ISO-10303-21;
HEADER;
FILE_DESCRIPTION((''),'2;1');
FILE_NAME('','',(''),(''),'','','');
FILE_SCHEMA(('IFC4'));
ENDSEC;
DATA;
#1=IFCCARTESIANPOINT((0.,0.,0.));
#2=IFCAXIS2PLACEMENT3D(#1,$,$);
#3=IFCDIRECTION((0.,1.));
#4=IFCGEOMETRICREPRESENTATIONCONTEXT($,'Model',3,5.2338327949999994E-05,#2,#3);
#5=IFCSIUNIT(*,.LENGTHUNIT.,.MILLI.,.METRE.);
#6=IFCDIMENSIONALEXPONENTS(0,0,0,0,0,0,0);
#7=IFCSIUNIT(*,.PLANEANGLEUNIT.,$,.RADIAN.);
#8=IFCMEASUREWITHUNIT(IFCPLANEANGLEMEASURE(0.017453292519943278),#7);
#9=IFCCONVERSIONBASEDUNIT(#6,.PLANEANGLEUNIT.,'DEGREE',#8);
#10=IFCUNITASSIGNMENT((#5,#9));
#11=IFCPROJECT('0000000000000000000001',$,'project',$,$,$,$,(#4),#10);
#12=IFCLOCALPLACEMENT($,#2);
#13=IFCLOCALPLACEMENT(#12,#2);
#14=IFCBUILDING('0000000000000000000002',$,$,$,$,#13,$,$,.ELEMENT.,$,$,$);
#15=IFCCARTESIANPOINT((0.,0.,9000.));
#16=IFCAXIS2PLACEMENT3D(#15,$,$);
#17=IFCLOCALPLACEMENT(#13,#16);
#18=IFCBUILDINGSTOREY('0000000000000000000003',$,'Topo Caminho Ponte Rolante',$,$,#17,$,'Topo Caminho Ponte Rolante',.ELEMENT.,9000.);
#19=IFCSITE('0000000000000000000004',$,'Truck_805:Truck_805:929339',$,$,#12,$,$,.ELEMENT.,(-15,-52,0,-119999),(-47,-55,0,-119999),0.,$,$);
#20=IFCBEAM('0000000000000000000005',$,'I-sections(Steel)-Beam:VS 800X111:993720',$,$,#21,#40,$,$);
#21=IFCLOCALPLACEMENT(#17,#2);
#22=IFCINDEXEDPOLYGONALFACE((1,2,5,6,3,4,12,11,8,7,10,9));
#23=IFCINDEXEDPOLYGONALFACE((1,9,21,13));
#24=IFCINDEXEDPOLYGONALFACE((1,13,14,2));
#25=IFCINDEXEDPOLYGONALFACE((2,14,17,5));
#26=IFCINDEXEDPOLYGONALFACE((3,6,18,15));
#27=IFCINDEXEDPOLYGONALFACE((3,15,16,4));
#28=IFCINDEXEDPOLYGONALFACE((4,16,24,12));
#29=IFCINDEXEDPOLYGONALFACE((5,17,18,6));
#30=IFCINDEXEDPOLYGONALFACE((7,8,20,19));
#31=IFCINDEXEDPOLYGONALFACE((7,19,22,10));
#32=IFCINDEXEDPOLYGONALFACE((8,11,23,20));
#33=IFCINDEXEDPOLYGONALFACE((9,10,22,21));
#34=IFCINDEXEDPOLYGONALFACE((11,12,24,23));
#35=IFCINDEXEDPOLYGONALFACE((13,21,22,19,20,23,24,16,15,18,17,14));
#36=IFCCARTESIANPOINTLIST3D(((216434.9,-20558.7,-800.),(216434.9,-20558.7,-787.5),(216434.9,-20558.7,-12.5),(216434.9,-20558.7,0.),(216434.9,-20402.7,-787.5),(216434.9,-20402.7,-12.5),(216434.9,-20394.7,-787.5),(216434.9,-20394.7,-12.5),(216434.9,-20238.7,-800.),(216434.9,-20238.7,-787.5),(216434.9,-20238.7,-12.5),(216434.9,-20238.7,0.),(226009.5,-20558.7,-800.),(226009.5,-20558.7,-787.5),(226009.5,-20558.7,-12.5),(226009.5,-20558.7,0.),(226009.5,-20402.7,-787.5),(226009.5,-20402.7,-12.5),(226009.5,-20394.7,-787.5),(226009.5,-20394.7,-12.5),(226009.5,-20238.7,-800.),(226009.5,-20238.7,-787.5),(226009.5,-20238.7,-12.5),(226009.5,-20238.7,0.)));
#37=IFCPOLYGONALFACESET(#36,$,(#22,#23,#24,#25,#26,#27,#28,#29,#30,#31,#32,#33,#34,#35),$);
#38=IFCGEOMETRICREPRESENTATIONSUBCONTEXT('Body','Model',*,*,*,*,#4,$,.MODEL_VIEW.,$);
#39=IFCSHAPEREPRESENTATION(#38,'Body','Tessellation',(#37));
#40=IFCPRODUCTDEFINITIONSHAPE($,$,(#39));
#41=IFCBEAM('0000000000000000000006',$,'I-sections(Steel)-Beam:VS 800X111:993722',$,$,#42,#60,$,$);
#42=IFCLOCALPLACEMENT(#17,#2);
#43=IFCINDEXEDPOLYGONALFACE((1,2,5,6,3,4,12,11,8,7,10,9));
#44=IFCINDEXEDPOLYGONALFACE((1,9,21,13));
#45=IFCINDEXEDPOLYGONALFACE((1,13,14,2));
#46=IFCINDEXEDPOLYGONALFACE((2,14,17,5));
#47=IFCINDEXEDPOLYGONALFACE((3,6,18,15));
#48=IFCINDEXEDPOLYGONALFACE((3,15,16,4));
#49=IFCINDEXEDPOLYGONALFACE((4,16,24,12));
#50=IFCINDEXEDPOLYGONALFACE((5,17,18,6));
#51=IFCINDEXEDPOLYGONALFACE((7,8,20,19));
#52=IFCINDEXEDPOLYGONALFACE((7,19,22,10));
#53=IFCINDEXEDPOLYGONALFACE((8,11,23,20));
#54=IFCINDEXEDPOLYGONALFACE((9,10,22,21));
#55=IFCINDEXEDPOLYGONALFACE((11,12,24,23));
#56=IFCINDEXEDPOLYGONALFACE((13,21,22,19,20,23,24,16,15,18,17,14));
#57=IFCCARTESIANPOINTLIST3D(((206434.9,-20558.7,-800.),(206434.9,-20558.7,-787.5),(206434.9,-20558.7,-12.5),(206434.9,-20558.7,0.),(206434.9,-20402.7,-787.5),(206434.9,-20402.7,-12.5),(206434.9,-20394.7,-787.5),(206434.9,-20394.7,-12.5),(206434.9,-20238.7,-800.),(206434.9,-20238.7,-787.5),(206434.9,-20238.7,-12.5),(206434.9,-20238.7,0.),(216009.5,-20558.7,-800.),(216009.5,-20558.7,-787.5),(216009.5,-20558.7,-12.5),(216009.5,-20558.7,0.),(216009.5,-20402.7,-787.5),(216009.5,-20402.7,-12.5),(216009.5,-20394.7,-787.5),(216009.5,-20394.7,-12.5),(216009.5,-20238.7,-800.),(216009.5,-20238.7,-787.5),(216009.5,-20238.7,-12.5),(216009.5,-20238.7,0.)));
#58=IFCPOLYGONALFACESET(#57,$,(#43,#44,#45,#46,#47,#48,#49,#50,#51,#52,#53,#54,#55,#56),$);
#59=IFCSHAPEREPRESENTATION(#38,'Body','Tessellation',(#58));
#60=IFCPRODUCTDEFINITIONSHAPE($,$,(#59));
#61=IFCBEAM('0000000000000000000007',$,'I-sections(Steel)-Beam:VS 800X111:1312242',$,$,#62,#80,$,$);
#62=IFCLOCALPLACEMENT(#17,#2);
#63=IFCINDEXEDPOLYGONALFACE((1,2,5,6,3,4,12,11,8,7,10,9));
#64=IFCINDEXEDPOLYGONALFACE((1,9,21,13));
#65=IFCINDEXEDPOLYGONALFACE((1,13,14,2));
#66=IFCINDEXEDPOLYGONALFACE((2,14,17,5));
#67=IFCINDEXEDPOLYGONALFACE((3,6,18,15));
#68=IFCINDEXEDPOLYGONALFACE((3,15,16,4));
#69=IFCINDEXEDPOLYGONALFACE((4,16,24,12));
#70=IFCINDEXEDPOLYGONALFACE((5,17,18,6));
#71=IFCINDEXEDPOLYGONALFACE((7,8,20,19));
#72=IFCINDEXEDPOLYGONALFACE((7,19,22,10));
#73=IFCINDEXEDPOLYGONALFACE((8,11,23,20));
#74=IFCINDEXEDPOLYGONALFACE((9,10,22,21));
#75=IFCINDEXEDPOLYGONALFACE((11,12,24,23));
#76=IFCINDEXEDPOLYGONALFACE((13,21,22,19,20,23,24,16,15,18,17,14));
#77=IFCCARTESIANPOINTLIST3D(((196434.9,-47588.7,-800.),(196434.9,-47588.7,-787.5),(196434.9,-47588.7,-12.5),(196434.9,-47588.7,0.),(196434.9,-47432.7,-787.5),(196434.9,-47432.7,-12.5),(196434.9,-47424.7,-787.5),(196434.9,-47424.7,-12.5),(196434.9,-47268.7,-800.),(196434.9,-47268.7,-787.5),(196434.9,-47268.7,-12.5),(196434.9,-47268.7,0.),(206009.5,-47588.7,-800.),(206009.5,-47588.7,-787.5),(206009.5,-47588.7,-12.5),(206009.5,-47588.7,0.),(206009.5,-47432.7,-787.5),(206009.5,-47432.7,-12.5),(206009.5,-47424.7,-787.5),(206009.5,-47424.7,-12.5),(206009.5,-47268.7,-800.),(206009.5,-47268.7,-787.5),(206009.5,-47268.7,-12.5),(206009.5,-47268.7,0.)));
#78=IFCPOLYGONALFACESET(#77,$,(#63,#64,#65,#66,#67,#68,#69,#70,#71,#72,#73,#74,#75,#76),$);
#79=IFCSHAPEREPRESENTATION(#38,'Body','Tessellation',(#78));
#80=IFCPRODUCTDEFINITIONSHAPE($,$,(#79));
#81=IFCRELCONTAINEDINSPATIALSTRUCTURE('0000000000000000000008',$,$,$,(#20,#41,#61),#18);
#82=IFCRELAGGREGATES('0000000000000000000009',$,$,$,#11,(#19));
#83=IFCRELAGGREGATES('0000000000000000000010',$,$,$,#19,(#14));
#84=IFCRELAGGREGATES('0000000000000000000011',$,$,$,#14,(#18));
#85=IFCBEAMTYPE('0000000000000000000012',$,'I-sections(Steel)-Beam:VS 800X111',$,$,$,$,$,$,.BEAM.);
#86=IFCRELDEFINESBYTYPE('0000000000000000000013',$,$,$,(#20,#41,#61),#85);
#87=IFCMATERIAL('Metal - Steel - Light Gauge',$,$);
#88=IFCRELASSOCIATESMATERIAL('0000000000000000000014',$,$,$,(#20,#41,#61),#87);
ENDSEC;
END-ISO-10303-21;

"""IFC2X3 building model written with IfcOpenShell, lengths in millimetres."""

from ifc_helpers import new_model, entity, si_unit, converted_unit, direction, frame, frame_2d, origin, place, context, subcontext, project, spatial, polyline, i_section, outline, extrude, material, type_object, element, save


model = new_model("IFC2X3")

# Units and contexts
model_context = context("Model", 3, precision=5.2338327949999994e-05, world=origin(), true_north=direction((0.0, 1.0)))
body_context = subcontext(model_context, "Body", "Model", "MODEL_VIEW")
ifc_project = project(units=[si_unit("LENGTHUNIT", "METRE", prefix="MILLI"), converted_unit("PLANEANGLEUNIT", "DEGREE", entity("IfcPlaneAngleMeasure", 0.017453292519943278), si_unit("PLANEANGLEUNIT", "RADIAN"), dimensions=[0, 0, 0, 0, 0, 0, 0])], contexts=[model_context])

# Site, building, storey
site_placement = place(None, origin())
site = spatial("IfcSite", under=ifc_project, at=site_placement, Name="Truck_805:Truck_805:929339", CompositionType="ELEMENT", RefLatitude=(-15, -52, 0, -119999), RefLongitude=(-47, -55, 0, -119999), RefElevation=0.0)
building_placement = place(site_placement, origin())
building = spatial("IfcBuilding", under=site, at=building_placement, CompositionType="ELEMENT")
storey_placement = place(building_placement, frame((0.0, 0.0, 9000.0)))
storey = spatial("IfcBuildingStorey", under=building, at=storey_placement, Name="Topo Caminho Ponte Rolante", LongName="Topo Caminho Ponte Rolante", CompositionType="ELEMENT", Elevation=9000.0)

# Beams
ifc_material = material(Name="Metal - Steel - Light Gauge")
beam_type_1 = type_object("IfcBeamType", Name="I-sections(Steel)-Beam:VS 800X111", PredefinedType="BEAM")
beam_1_placement = place(storey_placement, frame((216222.2, -20398.7, 0.0)))
element("IfcBeam", 1, at=beam_1_placement, inside=storey, type_object=beam_type_1, material=ifc_material, Name="I-sections(Steel)-Beam:VS 800X111:993720", context=body_context, shape_type="SweptSolid", body=[
    extrude(outline(polyline([(387.5, -160.0), (400.0, -160.0), (400.0, 160.0), (387.5, 160.0), (387.5, 4.0), (-387.5, 4.0), (-387.5, 160.0), (-400.0, 160.0), (-400.0, -160.0), (-387.5, -160.0), (-387.5, -4.0), (387.5, -4.0), (387.5, -160.0)])), frame((212.7, 0.0, -400.0), z_axis=(1.0, 0.0, 0.0), x_axis=(0.0, 0.0, -1.0)), (0.0, 0.0, 1.0), 9574.6),
])
beam_2_placement = place(storey_placement, frame((206222.2, -20398.7, 0.0)))
element("IfcBeam", 2, at=beam_2_placement, inside=storey, type_object=beam_type_1, material=ifc_material, Name="I-sections(Steel)-Beam:VS 800X111:993722", context=body_context, shape_type="SweptSolid", body=[
    extrude(outline(polyline([(387.5, -160.0), (400.0, -160.0), (400.0, 160.0), (387.5, 160.0), (387.5, 4.0), (-387.5, 4.0), (-387.5, 160.0), (-400.0, 160.0), (-400.0, -160.0), (-387.5, -160.0), (-387.5, -4.0), (387.5, -4.0), (387.5, -160.0)])), frame((212.7, 0.0, -400.0), z_axis=(1.0, 0.0, 0.0), x_axis=(0.0, 0.0, -1.0)), (0.0, 0.0, 1.0), 9574.6),
])
beam_3_placement = place(storey_placement, frame((196222.2, -47428.7, 0.0)))
element("IfcBeam", 3, at=beam_3_placement, inside=storey, type_object=beam_type_1, material=ifc_material, Name="I-sections(Steel)-Beam:VS 800X111:1312242", context=body_context, shape_type="SweptSolid", body=[
    extrude(i_section(OverallWidth=320.0, OverallDepth=800.0, WebThickness=8.0, FlangeThickness=12.5, at=frame_2d((0.0, 0.0), x_axis=(0.0, 1.0))), frame((212.7, 0.0, -400.0), z_axis=(1.0, 0.0, 0.0), x_axis=(0.0, 0.0, -1.0)), (0.0, 0.0, 1.0), 9574.6),
])

save(model, "model.ifc")
